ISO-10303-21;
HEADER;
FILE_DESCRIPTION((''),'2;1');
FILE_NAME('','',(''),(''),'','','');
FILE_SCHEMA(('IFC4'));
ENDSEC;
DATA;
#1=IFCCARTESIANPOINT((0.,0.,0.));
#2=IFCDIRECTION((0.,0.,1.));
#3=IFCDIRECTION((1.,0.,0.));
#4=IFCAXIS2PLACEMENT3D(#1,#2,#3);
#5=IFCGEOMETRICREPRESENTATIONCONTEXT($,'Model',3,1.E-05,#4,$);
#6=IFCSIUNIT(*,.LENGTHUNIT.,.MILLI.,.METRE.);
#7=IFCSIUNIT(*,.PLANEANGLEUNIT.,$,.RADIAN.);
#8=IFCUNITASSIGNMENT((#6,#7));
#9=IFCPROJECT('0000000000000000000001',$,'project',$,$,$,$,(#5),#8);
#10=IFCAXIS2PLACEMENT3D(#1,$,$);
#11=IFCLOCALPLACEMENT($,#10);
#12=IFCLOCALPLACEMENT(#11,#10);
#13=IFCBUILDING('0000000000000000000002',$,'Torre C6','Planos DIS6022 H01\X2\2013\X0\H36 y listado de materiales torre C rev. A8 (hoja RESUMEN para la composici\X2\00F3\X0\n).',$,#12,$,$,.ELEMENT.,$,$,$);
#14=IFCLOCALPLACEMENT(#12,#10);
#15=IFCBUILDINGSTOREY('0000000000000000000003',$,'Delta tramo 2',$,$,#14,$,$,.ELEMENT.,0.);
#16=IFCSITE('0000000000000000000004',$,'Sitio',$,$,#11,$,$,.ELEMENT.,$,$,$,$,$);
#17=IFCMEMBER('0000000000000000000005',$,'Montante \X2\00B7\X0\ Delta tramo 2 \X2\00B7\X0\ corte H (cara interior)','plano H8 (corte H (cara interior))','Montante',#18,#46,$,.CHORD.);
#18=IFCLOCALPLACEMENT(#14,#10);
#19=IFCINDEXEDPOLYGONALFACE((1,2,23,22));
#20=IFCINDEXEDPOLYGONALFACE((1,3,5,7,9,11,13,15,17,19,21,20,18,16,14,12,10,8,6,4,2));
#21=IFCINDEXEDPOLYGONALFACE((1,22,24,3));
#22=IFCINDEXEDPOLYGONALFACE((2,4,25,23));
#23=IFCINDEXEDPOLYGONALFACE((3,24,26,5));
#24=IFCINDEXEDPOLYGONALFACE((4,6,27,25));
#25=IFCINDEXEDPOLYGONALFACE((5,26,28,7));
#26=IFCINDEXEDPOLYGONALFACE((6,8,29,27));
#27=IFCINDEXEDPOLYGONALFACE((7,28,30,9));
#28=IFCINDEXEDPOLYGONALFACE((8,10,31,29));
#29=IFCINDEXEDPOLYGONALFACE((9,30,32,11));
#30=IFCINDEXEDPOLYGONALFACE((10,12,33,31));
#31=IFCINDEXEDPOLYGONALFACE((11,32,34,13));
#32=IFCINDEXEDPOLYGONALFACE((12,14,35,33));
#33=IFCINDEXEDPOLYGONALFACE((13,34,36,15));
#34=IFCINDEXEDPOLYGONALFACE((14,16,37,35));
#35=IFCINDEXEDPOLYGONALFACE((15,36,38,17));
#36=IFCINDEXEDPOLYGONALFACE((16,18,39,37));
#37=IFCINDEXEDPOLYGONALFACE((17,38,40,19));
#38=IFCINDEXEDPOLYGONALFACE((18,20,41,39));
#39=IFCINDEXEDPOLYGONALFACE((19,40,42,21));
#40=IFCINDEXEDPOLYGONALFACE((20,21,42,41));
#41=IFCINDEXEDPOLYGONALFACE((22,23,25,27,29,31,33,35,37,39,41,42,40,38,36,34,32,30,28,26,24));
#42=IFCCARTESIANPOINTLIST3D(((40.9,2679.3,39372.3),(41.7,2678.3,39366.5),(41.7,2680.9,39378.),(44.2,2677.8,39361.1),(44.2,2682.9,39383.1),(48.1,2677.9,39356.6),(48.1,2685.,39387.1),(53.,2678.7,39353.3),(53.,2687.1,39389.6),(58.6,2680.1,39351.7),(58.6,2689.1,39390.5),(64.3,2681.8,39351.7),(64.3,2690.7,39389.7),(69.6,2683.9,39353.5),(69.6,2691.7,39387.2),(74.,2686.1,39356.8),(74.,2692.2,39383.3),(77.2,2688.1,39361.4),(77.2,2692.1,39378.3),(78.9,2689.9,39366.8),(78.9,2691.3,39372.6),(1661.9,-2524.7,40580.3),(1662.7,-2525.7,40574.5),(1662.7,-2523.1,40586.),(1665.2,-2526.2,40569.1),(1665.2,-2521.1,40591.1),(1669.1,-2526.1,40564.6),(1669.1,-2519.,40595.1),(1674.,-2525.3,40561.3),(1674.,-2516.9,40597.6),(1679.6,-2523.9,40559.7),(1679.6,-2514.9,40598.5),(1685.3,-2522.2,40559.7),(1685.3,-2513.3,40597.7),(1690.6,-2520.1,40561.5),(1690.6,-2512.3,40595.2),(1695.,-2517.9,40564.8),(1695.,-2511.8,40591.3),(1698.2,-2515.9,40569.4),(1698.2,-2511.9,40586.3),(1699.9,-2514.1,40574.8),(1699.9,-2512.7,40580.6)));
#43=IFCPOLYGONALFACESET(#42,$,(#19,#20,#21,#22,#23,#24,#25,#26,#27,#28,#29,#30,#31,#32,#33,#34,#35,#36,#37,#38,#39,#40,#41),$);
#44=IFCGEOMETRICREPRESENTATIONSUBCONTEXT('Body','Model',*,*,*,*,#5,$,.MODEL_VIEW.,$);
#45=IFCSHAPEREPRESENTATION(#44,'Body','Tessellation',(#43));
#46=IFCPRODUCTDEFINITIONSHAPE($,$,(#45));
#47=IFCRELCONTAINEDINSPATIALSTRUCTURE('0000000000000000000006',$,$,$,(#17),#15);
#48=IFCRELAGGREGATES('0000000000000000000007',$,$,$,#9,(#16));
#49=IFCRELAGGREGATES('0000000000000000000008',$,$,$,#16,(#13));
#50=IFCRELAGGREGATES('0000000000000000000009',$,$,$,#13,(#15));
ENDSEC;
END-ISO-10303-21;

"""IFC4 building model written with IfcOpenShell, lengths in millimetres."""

from ifc_helpers import new_model, si_unit, frame, origin, origin_with_axes, place, context, subcontext, project, spatial, circle, extrude, element, save


model = new_model("IFC4")

# Units and contexts
model_context = context("Model", 3, precision=1e-05, world=origin_with_axes())
body_context = subcontext(model_context, "Body", "Model", "MODEL_VIEW")
ifc_project = project(units=[si_unit("LENGTHUNIT", "METRE", prefix="MILLI"), si_unit("PLANEANGLEUNIT", "RADIAN")], contexts=[model_context])

# Site, building, storey
site_placement = place(None, origin())
site = spatial("IfcSite", under=ifc_project, at=site_placement, Name="Sitio", CompositionType="ELEMENT")
building_placement = place(site_placement, origin())
building = spatial("IfcBuilding", under=site, at=building_placement, Name="Torre C6", Description="Planos DIS6022 H01–H36 y listado de materiales torre C rev. A8 (hoja RESUMEN para la composición).", CompositionType="ELEMENT")
storey_placement = place(building_placement, origin())
storey = spatial("IfcBuildingStorey", under=building, at=storey_placement, Name="Delta tramo 2", CompositionType="ELEMENT", Elevation=0.0)

# Member
member_1_placement = place(storey_placement, frame((60.0, 2685.0, 39371.0), z_axis=(0.290352, -0.932136, 0.216376), x_axis=(-0.95692, -0.282832, 0.065654)))
element("IfcMember", 1, at=member_1_placement, inside=storey, Name="Montante · Delta tramo 2 · corte H (cara interior)", Description="plano H8 (corte H (cara interior))", ObjectType="Montante", PredefinedType="CHORD", context=body_context, shape_type="SweptSolid", body=[
    extrude(circle(Radius=20.0), None, (0.0, 0.0, 1.0), 5582.9),
])

save(model, "model.ifc")
